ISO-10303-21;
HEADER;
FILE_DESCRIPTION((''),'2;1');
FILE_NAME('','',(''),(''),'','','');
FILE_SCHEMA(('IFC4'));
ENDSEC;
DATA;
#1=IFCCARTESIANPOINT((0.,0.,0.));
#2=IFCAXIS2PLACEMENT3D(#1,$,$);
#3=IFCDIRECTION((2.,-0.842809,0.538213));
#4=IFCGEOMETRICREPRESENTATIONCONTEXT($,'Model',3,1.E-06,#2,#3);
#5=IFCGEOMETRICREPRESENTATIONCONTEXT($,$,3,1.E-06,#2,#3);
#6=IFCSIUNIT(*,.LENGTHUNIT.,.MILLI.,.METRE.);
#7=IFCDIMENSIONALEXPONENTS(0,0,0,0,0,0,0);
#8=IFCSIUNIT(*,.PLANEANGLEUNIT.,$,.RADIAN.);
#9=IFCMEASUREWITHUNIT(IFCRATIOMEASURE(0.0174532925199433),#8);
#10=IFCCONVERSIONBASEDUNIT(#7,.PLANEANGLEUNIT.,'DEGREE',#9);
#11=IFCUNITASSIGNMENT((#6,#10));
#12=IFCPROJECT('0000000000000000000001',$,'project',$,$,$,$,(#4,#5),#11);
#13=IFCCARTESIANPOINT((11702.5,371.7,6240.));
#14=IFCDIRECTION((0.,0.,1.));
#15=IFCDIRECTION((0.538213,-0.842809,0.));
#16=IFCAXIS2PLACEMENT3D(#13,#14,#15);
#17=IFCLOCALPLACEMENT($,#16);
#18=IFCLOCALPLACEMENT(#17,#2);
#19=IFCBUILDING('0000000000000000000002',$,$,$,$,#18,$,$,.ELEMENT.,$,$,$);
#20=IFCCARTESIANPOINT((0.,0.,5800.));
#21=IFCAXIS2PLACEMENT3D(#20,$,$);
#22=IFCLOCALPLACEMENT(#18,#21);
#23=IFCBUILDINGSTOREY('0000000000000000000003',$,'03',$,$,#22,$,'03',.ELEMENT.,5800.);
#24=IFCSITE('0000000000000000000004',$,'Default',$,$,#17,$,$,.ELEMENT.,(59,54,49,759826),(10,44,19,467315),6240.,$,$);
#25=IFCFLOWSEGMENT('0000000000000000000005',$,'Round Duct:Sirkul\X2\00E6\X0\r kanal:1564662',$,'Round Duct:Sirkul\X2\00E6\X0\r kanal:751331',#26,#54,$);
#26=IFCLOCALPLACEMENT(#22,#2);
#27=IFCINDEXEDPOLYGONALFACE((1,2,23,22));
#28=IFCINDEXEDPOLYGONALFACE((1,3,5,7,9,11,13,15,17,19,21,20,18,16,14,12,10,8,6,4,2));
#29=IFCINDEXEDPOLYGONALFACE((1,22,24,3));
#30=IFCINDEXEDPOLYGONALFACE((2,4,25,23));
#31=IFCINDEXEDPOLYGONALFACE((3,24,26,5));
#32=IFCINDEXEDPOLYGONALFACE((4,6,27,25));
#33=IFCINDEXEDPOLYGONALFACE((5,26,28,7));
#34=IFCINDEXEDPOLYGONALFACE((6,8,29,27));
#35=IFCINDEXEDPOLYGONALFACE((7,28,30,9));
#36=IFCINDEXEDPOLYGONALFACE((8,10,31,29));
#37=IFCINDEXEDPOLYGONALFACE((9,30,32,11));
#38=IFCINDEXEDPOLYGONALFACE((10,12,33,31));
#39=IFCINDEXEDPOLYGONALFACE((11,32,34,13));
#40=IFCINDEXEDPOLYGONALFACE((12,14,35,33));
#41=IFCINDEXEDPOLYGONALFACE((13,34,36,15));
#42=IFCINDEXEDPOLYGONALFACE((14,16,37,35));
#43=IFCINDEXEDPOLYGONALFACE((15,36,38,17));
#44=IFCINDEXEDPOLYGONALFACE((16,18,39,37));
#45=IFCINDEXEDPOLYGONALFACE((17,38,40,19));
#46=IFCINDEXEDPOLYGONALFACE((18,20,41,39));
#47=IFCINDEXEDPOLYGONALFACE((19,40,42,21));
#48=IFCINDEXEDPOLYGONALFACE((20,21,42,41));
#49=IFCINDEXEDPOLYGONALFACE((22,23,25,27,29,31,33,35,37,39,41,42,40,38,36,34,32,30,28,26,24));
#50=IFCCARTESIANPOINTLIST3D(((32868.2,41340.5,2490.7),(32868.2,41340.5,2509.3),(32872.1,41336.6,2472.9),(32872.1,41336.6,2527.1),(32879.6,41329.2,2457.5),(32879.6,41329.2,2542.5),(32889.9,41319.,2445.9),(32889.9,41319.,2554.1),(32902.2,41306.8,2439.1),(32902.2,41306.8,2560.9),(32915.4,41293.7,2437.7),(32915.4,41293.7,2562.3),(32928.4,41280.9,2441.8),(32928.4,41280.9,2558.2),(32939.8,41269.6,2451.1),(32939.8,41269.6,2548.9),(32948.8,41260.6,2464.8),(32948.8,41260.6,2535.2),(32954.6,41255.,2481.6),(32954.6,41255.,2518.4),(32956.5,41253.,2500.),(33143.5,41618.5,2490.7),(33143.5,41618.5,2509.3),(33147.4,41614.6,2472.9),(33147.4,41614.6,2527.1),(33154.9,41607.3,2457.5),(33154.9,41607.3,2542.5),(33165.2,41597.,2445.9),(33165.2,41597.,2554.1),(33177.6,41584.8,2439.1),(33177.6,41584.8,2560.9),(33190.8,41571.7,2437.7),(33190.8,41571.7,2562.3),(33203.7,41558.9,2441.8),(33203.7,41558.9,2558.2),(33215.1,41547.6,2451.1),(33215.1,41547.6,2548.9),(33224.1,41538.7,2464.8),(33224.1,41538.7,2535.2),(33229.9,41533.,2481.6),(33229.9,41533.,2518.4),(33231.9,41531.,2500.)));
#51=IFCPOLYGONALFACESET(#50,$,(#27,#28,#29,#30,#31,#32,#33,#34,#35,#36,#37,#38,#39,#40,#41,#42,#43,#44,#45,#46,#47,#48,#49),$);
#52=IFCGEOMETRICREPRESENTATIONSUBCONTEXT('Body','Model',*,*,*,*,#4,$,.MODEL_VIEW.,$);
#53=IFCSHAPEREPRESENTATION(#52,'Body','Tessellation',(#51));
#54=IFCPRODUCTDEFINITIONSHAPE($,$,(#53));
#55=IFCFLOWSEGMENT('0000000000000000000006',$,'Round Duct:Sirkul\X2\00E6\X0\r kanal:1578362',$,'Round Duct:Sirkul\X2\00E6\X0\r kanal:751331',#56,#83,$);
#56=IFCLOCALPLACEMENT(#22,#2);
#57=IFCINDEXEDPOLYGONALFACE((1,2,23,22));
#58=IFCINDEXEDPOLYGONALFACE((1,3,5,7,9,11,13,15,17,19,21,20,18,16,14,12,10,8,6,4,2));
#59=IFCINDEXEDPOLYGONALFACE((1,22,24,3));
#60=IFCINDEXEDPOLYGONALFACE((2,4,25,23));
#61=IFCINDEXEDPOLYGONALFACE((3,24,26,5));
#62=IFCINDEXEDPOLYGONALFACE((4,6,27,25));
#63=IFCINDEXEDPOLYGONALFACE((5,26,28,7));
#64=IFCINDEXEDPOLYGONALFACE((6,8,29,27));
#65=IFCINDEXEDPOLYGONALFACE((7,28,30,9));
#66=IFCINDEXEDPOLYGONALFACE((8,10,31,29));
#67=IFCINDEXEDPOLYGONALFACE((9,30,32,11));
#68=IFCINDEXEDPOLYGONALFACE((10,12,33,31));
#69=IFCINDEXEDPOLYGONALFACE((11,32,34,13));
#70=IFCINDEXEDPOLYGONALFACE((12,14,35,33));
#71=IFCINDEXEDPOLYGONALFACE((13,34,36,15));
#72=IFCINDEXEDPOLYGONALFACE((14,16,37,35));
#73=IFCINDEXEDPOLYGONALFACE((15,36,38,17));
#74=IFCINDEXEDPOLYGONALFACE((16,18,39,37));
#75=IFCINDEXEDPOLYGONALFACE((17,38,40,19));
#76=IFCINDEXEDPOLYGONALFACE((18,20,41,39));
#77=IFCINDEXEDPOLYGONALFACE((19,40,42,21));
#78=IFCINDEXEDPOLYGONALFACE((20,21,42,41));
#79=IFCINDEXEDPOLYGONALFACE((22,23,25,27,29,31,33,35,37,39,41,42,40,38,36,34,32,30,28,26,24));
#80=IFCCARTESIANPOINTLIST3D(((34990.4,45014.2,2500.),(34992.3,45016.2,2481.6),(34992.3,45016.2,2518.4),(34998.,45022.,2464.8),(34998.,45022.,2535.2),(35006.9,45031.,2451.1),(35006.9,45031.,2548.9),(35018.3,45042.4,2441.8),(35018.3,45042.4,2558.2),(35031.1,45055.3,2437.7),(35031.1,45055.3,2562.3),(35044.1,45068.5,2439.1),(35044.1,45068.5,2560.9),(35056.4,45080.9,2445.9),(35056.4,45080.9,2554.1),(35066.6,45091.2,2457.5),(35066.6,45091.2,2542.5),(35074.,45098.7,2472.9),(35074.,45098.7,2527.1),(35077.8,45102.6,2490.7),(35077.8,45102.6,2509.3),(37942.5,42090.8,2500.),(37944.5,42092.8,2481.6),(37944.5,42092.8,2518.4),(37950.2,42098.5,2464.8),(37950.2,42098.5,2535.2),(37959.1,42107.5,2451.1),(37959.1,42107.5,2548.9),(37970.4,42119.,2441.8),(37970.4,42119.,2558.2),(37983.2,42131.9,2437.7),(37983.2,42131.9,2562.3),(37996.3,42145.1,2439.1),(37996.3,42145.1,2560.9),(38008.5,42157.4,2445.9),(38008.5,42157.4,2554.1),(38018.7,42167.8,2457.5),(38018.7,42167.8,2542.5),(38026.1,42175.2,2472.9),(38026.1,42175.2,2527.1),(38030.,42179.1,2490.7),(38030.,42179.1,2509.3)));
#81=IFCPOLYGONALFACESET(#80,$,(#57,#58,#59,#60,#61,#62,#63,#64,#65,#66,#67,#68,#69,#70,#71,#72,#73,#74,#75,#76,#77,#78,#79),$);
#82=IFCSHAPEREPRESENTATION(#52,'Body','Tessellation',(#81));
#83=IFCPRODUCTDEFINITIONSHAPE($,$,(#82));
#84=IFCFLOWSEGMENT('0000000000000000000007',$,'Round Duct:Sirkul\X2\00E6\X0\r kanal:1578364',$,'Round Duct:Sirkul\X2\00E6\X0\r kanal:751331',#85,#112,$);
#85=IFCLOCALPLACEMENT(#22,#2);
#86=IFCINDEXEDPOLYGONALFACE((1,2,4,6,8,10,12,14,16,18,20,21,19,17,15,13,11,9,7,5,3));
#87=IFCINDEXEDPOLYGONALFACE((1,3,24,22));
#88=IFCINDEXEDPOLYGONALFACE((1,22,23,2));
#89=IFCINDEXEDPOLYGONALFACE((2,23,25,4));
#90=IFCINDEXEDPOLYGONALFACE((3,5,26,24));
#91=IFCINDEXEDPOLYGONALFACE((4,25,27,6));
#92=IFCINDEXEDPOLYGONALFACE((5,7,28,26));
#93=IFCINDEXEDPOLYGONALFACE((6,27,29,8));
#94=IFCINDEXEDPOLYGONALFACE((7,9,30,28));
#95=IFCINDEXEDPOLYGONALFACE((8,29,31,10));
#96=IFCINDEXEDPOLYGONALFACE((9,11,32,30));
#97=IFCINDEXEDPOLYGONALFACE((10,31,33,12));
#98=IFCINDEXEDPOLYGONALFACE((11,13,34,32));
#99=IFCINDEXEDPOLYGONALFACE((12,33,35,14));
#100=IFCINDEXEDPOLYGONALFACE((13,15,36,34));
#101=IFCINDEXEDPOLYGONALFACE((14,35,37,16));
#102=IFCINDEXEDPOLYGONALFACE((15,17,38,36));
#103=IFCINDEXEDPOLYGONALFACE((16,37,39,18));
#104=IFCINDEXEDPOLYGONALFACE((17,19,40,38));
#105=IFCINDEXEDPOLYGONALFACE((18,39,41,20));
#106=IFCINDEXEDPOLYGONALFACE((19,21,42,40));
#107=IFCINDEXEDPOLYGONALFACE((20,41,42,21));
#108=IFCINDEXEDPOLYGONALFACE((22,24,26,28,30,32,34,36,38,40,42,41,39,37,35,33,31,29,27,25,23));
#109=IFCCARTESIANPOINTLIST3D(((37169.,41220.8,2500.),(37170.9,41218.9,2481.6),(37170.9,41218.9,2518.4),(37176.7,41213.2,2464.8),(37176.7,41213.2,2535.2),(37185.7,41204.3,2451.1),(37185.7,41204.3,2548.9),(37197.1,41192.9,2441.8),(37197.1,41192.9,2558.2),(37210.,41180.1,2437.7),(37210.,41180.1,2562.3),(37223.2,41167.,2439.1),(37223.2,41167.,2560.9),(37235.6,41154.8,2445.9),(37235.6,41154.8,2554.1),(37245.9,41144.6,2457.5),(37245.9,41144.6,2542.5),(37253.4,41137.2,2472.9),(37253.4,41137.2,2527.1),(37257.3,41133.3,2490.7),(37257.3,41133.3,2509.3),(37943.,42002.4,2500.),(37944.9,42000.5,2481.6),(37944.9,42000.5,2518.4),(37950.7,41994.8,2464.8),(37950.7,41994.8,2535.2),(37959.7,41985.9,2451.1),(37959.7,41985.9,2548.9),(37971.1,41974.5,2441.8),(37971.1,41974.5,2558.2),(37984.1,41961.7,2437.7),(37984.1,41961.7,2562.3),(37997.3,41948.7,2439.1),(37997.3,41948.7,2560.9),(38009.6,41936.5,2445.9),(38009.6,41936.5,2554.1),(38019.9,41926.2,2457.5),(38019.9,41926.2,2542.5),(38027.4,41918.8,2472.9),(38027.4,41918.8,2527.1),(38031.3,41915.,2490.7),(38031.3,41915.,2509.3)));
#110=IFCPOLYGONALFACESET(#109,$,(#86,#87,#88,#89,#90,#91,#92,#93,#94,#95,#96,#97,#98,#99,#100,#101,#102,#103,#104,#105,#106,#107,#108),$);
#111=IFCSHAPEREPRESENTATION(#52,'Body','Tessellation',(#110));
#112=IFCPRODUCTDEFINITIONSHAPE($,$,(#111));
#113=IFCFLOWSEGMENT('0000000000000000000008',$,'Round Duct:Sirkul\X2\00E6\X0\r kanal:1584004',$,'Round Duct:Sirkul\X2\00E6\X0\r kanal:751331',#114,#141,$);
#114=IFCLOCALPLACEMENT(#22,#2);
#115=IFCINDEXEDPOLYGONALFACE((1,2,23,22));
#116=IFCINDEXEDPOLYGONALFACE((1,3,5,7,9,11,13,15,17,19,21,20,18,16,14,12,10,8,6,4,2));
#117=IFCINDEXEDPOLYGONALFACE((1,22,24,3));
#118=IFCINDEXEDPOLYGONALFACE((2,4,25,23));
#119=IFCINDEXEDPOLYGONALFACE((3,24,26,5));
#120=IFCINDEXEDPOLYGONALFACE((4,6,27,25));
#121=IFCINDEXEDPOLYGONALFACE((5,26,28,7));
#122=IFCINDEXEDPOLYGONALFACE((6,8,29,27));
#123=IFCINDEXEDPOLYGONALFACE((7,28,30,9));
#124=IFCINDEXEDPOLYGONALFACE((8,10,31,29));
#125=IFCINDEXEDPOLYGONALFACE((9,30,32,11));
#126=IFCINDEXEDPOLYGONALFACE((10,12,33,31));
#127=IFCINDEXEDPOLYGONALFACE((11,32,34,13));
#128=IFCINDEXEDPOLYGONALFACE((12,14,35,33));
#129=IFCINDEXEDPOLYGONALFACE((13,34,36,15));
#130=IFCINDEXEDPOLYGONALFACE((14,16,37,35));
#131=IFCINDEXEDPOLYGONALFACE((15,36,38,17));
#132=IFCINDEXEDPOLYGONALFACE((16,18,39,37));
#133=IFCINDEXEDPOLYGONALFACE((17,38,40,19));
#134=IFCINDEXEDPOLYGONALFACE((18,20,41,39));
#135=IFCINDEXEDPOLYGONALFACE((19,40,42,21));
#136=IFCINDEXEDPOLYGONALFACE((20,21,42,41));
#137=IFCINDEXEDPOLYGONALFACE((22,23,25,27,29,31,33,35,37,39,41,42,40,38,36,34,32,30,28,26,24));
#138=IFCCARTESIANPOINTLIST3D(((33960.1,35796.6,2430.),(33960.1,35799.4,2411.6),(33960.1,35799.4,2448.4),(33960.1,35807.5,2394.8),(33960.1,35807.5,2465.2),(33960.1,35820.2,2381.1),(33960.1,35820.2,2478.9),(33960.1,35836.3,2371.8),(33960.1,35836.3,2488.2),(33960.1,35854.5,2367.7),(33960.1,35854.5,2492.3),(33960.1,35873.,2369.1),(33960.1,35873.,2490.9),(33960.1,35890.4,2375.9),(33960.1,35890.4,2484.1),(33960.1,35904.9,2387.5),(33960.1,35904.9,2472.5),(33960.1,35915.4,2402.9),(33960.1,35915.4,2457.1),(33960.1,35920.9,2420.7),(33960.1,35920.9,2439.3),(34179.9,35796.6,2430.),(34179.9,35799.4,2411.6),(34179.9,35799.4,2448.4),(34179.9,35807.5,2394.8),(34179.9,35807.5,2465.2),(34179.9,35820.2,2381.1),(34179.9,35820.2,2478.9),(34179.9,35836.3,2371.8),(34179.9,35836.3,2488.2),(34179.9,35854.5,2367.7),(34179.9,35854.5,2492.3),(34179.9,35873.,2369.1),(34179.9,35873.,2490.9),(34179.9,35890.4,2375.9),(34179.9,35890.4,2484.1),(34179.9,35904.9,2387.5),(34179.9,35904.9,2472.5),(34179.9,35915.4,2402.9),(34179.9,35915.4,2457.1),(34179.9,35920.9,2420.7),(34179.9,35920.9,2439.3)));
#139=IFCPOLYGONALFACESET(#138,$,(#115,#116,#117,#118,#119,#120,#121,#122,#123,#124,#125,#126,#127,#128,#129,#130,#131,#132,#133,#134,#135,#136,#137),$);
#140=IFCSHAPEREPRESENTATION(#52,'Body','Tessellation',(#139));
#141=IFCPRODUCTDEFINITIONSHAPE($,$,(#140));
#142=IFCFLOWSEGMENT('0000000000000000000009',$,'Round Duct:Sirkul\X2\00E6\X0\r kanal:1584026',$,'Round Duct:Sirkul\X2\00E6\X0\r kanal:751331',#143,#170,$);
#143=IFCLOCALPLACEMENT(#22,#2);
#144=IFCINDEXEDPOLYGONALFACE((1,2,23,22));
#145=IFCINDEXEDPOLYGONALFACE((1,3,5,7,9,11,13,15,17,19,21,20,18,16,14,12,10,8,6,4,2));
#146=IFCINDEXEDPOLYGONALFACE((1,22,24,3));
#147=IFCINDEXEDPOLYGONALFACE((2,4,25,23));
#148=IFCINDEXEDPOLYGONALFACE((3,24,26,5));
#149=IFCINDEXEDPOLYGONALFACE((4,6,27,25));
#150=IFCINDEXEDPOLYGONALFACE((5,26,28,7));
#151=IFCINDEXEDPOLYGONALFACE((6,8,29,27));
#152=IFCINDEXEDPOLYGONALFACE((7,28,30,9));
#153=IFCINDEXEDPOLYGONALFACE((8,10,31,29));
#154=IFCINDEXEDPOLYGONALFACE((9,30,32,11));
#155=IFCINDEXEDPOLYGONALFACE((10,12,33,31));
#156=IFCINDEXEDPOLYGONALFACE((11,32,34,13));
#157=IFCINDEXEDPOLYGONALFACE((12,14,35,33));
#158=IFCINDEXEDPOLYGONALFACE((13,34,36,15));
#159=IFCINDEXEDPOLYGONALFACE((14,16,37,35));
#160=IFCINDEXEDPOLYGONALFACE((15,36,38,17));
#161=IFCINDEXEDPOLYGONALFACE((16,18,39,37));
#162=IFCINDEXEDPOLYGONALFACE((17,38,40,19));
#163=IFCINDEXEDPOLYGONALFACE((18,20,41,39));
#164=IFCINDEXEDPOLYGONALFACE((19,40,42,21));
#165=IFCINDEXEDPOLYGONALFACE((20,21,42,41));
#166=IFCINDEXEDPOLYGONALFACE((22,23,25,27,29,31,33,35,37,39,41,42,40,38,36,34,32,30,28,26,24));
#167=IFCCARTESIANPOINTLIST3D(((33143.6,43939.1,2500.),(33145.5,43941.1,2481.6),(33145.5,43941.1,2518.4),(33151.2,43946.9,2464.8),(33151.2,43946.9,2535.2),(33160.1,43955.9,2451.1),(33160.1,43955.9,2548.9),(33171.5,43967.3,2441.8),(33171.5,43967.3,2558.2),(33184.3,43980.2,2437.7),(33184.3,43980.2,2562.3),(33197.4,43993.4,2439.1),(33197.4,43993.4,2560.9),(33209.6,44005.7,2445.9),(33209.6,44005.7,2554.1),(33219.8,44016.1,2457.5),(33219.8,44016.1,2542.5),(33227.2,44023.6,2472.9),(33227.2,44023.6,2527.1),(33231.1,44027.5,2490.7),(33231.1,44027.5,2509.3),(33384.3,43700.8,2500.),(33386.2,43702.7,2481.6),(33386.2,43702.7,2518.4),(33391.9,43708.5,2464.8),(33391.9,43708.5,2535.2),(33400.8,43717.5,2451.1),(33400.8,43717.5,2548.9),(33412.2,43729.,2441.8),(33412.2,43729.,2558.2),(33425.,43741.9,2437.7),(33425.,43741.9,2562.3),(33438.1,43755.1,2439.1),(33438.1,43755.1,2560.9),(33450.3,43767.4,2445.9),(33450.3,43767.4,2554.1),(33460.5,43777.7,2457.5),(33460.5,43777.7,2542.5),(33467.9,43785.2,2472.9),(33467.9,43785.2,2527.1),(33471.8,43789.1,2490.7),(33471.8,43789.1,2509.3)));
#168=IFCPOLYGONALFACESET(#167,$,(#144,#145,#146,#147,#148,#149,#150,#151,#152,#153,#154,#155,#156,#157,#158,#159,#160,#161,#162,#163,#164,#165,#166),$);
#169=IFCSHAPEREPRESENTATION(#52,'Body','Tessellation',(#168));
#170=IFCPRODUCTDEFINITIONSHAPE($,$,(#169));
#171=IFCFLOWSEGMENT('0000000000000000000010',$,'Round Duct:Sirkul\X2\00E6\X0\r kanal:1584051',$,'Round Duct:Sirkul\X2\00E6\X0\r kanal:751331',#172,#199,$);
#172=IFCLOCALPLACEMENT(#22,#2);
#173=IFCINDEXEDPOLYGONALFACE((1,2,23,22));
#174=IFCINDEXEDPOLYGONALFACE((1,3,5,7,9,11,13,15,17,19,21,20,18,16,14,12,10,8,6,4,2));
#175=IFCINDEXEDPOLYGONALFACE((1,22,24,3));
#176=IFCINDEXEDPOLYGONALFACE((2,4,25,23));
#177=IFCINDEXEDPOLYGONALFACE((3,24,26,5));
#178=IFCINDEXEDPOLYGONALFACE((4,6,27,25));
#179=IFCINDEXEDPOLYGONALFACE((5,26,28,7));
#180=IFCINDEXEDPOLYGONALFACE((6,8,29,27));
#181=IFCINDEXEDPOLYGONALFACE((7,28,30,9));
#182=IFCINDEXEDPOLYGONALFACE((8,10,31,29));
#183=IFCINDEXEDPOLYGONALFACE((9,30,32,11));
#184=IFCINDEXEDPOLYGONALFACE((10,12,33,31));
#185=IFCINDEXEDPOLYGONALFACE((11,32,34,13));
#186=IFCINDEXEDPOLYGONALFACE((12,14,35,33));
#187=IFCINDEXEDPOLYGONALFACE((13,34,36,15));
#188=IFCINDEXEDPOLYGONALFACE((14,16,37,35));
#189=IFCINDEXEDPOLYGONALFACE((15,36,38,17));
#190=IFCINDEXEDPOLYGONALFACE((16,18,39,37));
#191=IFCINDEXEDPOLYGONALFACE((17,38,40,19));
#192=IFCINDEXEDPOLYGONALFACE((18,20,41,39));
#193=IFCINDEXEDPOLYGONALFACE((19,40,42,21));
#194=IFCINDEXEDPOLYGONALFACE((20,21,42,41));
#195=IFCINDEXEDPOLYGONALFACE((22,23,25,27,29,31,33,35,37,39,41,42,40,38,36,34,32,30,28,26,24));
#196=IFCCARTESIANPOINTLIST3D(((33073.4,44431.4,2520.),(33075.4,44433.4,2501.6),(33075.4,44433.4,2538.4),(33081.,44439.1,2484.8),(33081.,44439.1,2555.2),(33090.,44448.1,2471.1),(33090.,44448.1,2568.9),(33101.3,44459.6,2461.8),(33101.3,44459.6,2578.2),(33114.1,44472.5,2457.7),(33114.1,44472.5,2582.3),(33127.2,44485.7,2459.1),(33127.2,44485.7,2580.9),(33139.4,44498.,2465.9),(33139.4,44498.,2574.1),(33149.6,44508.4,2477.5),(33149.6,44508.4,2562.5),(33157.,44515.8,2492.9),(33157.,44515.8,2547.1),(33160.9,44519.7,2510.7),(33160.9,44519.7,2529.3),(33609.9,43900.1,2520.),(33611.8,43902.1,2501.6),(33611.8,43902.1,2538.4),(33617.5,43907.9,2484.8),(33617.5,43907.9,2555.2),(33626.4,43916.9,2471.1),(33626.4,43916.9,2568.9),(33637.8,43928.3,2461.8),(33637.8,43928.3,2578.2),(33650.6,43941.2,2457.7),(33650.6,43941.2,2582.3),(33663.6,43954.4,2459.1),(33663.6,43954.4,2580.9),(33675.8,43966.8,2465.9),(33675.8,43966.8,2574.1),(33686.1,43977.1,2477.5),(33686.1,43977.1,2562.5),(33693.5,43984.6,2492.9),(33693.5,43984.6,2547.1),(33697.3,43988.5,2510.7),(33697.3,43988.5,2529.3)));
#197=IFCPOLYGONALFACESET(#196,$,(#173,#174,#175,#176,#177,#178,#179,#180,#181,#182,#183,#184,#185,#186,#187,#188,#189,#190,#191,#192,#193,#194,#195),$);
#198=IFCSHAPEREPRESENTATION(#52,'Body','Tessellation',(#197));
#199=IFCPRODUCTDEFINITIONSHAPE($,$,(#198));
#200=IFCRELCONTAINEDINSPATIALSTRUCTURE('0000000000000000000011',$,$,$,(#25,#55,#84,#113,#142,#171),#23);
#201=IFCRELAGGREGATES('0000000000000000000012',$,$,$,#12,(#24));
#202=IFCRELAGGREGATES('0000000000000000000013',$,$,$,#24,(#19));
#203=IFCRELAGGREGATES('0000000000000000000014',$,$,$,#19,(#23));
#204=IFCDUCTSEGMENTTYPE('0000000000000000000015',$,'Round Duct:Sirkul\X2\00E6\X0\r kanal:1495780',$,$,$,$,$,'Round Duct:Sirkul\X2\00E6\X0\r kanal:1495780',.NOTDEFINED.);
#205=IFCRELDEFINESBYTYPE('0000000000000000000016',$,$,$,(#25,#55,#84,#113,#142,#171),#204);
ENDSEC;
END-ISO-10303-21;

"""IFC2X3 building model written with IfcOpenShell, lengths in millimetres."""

from ifc_helpers import new_model, entity, si_unit, converted_unit, direction, frame, frame_2d, origin, origin_2d_with_axis, place, context, subcontext, project, spatial, circle, extrude, type_object, element, save


model = new_model("IFC2X3")

# Units and contexts
model_context = context("Model", 3, precision=1e-06, world=origin(), true_north=direction((2.0, -0.842809, 0.538213)))
context_of_model = context(None, 3, precision=1e-06, world=origin(), true_north=direction((2.0, -0.842809, 0.538213)))
body_context = subcontext(model_context, "Body", "Model", "MODEL_VIEW")
ifc_project = project(units=[si_unit("LENGTHUNIT", "METRE", prefix="MILLI"), converted_unit("PLANEANGLEUNIT", "DEGREE", entity("IfcRatioMeasure", 0.0174532925199433), si_unit("PLANEANGLEUNIT", "RADIAN"), dimensions=[0, 0, 0, 0, 0, 0, 0])], contexts=[model_context, context_of_model])

# Site, building, storey
site_placement = place(None, frame((11702.5, 371.7, 6240.0), z_axis=(0.0, 0.0, 1.0), x_axis=(0.538213, -0.842809, 0.0)))
site = spatial("IfcSite", under=ifc_project, at=site_placement, Name="Default", CompositionType="ELEMENT", RefLatitude=(59, 54, 49, 759826), RefLongitude=(10, 44, 19, 467315), RefElevation=6240.0)
building_placement = place(site_placement, origin())
building = spatial("IfcBuilding", under=site, at=building_placement, CompositionType="ELEMENT")
storey_placement = place(building_placement, frame((0.0, 0.0, 5800.0)))
storey = spatial("IfcBuildingStorey", under=building, at=storey_placement, Name="03", LongName="03", CompositionType="ELEMENT", Elevation=5800.0)

# Flow segments
duct_segment_type = type_object("IfcDuctSegmentType", Name="Round Duct:Sirkulær kanal:1495780", ElementType="Round Duct:Sirkulær kanal:1495780", PredefinedType="NOTDEFINED")
flow_segment_1_placement = place(storey_placement, origin())
element("IfcFlowSegment", 1, at=flow_segment_1_placement, inside=storey, type_object=duct_segment_type, Name="Round Duct:Sirkulær kanal:1564662", ObjectType="Round Duct:Sirkulær kanal:751331", context=body_context, shape_type="SweptSolid", body=[
    extrude(circle(Radius=62.5, at=origin_2d_with_axis()), frame((32912.1, 41297.0, 2500.0), z_axis=(0.703643, 0.710554, 0.0), x_axis=(0.710554, -0.703643, 0.0)), (0.0, 0.0, 1.0), 391.3),
])
flow_segment_2_placement = place(storey_placement, origin())
element("IfcFlowSegment", 2, at=flow_segment_2_placement, inside=storey, type_object=duct_segment_type, Name="Round Duct:Sirkulær kanal:1578362", ObjectType="Round Duct:Sirkulær kanal:751331", context=body_context, shape_type="SweptSolid", body=[
    extrude(circle(Radius=62.5, at=origin_2d_with_axis()), frame((35034.4, 45058.6, 2500.0), z_axis=(0.710554, -0.703643, 0.0), x_axis=(-0.703643, -0.710554, 0.0)), (0.0, 0.0, 1.0), 4154.7),
])
flow_segment_3_placement = place(storey_placement, origin())
element("IfcFlowSegment", 3, at=flow_segment_3_placement, inside=storey, type_object=duct_segment_type, Name="Round Duct:Sirkulær kanal:1578364", ObjectType="Round Duct:Sirkulær kanal:751331", context=body_context, shape_type="SweptSolid", body=[
    extrude(circle(Radius=62.5, at=frame_2d((0.0, 0.0), x_axis=(1.0, 0.0))), frame((37213.4, 41176.8, 2500.0), z_axis=(0.703643, 0.710554, 0.0), x_axis=(-0.710554, 0.703643, 0.0)), (0.0, 0.0, 1.0), 1100.0),
])
flow_segment_4_placement = place(storey_placement, origin())
element("IfcFlowSegment", 4, at=flow_segment_4_placement, inside=storey, type_object=duct_segment_type, Name="Round Duct:Sirkulær kanal:1584004", ObjectType="Round Duct:Sirkulær kanal:751331", context=body_context, shape_type="SweptSolid", body=[
    extrude(circle(Radius=62.5, at=origin_2d_with_axis()), frame((33960.1, 35859.1, 2430.0), z_axis=(1.0, 0.0, 0.0), x_axis=(0.0, -1.0, 0.0)), (0.0, 0.0, 1.0), 219.8),
])
flow_segment_5_placement = place(storey_placement, origin())
element("IfcFlowSegment", 5, at=flow_segment_5_placement, inside=storey, type_object=duct_segment_type, Name="Round Duct:Sirkulær kanal:1584026", ObjectType="Round Duct:Sirkulær kanal:751331", context=body_context, shape_type="SweptSolid", body=[
    extrude(circle(Radius=62.5, at=origin_2d_with_axis()), frame((33187.6, 43983.5, 2500.0), z_axis=(0.710554, -0.703643, 0.0), x_axis=(-0.703643, -0.710554, 0.0)), (0.0, 0.0, 1.0), 338.8),
])
flow_segment_6_placement = place(storey_placement, origin())
element("IfcFlowSegment", 6, at=flow_segment_6_placement, inside=storey, type_object=duct_segment_type, Name="Round Duct:Sirkulær kanal:1584051", ObjectType="Round Duct:Sirkulær kanal:751331", context=body_context, shape_type="SweptSolid", body=[
    extrude(circle(Radius=62.5, at=origin_2d_with_axis()), frame((33117.4, 44475.8, 2520.0), z_axis=(0.710554, -0.703643, 0.0), x_axis=(-0.703643, -0.710554, 0.0)), (0.0, 0.0, 1.0), 755.0),
])

save(model, "model.ifc")
